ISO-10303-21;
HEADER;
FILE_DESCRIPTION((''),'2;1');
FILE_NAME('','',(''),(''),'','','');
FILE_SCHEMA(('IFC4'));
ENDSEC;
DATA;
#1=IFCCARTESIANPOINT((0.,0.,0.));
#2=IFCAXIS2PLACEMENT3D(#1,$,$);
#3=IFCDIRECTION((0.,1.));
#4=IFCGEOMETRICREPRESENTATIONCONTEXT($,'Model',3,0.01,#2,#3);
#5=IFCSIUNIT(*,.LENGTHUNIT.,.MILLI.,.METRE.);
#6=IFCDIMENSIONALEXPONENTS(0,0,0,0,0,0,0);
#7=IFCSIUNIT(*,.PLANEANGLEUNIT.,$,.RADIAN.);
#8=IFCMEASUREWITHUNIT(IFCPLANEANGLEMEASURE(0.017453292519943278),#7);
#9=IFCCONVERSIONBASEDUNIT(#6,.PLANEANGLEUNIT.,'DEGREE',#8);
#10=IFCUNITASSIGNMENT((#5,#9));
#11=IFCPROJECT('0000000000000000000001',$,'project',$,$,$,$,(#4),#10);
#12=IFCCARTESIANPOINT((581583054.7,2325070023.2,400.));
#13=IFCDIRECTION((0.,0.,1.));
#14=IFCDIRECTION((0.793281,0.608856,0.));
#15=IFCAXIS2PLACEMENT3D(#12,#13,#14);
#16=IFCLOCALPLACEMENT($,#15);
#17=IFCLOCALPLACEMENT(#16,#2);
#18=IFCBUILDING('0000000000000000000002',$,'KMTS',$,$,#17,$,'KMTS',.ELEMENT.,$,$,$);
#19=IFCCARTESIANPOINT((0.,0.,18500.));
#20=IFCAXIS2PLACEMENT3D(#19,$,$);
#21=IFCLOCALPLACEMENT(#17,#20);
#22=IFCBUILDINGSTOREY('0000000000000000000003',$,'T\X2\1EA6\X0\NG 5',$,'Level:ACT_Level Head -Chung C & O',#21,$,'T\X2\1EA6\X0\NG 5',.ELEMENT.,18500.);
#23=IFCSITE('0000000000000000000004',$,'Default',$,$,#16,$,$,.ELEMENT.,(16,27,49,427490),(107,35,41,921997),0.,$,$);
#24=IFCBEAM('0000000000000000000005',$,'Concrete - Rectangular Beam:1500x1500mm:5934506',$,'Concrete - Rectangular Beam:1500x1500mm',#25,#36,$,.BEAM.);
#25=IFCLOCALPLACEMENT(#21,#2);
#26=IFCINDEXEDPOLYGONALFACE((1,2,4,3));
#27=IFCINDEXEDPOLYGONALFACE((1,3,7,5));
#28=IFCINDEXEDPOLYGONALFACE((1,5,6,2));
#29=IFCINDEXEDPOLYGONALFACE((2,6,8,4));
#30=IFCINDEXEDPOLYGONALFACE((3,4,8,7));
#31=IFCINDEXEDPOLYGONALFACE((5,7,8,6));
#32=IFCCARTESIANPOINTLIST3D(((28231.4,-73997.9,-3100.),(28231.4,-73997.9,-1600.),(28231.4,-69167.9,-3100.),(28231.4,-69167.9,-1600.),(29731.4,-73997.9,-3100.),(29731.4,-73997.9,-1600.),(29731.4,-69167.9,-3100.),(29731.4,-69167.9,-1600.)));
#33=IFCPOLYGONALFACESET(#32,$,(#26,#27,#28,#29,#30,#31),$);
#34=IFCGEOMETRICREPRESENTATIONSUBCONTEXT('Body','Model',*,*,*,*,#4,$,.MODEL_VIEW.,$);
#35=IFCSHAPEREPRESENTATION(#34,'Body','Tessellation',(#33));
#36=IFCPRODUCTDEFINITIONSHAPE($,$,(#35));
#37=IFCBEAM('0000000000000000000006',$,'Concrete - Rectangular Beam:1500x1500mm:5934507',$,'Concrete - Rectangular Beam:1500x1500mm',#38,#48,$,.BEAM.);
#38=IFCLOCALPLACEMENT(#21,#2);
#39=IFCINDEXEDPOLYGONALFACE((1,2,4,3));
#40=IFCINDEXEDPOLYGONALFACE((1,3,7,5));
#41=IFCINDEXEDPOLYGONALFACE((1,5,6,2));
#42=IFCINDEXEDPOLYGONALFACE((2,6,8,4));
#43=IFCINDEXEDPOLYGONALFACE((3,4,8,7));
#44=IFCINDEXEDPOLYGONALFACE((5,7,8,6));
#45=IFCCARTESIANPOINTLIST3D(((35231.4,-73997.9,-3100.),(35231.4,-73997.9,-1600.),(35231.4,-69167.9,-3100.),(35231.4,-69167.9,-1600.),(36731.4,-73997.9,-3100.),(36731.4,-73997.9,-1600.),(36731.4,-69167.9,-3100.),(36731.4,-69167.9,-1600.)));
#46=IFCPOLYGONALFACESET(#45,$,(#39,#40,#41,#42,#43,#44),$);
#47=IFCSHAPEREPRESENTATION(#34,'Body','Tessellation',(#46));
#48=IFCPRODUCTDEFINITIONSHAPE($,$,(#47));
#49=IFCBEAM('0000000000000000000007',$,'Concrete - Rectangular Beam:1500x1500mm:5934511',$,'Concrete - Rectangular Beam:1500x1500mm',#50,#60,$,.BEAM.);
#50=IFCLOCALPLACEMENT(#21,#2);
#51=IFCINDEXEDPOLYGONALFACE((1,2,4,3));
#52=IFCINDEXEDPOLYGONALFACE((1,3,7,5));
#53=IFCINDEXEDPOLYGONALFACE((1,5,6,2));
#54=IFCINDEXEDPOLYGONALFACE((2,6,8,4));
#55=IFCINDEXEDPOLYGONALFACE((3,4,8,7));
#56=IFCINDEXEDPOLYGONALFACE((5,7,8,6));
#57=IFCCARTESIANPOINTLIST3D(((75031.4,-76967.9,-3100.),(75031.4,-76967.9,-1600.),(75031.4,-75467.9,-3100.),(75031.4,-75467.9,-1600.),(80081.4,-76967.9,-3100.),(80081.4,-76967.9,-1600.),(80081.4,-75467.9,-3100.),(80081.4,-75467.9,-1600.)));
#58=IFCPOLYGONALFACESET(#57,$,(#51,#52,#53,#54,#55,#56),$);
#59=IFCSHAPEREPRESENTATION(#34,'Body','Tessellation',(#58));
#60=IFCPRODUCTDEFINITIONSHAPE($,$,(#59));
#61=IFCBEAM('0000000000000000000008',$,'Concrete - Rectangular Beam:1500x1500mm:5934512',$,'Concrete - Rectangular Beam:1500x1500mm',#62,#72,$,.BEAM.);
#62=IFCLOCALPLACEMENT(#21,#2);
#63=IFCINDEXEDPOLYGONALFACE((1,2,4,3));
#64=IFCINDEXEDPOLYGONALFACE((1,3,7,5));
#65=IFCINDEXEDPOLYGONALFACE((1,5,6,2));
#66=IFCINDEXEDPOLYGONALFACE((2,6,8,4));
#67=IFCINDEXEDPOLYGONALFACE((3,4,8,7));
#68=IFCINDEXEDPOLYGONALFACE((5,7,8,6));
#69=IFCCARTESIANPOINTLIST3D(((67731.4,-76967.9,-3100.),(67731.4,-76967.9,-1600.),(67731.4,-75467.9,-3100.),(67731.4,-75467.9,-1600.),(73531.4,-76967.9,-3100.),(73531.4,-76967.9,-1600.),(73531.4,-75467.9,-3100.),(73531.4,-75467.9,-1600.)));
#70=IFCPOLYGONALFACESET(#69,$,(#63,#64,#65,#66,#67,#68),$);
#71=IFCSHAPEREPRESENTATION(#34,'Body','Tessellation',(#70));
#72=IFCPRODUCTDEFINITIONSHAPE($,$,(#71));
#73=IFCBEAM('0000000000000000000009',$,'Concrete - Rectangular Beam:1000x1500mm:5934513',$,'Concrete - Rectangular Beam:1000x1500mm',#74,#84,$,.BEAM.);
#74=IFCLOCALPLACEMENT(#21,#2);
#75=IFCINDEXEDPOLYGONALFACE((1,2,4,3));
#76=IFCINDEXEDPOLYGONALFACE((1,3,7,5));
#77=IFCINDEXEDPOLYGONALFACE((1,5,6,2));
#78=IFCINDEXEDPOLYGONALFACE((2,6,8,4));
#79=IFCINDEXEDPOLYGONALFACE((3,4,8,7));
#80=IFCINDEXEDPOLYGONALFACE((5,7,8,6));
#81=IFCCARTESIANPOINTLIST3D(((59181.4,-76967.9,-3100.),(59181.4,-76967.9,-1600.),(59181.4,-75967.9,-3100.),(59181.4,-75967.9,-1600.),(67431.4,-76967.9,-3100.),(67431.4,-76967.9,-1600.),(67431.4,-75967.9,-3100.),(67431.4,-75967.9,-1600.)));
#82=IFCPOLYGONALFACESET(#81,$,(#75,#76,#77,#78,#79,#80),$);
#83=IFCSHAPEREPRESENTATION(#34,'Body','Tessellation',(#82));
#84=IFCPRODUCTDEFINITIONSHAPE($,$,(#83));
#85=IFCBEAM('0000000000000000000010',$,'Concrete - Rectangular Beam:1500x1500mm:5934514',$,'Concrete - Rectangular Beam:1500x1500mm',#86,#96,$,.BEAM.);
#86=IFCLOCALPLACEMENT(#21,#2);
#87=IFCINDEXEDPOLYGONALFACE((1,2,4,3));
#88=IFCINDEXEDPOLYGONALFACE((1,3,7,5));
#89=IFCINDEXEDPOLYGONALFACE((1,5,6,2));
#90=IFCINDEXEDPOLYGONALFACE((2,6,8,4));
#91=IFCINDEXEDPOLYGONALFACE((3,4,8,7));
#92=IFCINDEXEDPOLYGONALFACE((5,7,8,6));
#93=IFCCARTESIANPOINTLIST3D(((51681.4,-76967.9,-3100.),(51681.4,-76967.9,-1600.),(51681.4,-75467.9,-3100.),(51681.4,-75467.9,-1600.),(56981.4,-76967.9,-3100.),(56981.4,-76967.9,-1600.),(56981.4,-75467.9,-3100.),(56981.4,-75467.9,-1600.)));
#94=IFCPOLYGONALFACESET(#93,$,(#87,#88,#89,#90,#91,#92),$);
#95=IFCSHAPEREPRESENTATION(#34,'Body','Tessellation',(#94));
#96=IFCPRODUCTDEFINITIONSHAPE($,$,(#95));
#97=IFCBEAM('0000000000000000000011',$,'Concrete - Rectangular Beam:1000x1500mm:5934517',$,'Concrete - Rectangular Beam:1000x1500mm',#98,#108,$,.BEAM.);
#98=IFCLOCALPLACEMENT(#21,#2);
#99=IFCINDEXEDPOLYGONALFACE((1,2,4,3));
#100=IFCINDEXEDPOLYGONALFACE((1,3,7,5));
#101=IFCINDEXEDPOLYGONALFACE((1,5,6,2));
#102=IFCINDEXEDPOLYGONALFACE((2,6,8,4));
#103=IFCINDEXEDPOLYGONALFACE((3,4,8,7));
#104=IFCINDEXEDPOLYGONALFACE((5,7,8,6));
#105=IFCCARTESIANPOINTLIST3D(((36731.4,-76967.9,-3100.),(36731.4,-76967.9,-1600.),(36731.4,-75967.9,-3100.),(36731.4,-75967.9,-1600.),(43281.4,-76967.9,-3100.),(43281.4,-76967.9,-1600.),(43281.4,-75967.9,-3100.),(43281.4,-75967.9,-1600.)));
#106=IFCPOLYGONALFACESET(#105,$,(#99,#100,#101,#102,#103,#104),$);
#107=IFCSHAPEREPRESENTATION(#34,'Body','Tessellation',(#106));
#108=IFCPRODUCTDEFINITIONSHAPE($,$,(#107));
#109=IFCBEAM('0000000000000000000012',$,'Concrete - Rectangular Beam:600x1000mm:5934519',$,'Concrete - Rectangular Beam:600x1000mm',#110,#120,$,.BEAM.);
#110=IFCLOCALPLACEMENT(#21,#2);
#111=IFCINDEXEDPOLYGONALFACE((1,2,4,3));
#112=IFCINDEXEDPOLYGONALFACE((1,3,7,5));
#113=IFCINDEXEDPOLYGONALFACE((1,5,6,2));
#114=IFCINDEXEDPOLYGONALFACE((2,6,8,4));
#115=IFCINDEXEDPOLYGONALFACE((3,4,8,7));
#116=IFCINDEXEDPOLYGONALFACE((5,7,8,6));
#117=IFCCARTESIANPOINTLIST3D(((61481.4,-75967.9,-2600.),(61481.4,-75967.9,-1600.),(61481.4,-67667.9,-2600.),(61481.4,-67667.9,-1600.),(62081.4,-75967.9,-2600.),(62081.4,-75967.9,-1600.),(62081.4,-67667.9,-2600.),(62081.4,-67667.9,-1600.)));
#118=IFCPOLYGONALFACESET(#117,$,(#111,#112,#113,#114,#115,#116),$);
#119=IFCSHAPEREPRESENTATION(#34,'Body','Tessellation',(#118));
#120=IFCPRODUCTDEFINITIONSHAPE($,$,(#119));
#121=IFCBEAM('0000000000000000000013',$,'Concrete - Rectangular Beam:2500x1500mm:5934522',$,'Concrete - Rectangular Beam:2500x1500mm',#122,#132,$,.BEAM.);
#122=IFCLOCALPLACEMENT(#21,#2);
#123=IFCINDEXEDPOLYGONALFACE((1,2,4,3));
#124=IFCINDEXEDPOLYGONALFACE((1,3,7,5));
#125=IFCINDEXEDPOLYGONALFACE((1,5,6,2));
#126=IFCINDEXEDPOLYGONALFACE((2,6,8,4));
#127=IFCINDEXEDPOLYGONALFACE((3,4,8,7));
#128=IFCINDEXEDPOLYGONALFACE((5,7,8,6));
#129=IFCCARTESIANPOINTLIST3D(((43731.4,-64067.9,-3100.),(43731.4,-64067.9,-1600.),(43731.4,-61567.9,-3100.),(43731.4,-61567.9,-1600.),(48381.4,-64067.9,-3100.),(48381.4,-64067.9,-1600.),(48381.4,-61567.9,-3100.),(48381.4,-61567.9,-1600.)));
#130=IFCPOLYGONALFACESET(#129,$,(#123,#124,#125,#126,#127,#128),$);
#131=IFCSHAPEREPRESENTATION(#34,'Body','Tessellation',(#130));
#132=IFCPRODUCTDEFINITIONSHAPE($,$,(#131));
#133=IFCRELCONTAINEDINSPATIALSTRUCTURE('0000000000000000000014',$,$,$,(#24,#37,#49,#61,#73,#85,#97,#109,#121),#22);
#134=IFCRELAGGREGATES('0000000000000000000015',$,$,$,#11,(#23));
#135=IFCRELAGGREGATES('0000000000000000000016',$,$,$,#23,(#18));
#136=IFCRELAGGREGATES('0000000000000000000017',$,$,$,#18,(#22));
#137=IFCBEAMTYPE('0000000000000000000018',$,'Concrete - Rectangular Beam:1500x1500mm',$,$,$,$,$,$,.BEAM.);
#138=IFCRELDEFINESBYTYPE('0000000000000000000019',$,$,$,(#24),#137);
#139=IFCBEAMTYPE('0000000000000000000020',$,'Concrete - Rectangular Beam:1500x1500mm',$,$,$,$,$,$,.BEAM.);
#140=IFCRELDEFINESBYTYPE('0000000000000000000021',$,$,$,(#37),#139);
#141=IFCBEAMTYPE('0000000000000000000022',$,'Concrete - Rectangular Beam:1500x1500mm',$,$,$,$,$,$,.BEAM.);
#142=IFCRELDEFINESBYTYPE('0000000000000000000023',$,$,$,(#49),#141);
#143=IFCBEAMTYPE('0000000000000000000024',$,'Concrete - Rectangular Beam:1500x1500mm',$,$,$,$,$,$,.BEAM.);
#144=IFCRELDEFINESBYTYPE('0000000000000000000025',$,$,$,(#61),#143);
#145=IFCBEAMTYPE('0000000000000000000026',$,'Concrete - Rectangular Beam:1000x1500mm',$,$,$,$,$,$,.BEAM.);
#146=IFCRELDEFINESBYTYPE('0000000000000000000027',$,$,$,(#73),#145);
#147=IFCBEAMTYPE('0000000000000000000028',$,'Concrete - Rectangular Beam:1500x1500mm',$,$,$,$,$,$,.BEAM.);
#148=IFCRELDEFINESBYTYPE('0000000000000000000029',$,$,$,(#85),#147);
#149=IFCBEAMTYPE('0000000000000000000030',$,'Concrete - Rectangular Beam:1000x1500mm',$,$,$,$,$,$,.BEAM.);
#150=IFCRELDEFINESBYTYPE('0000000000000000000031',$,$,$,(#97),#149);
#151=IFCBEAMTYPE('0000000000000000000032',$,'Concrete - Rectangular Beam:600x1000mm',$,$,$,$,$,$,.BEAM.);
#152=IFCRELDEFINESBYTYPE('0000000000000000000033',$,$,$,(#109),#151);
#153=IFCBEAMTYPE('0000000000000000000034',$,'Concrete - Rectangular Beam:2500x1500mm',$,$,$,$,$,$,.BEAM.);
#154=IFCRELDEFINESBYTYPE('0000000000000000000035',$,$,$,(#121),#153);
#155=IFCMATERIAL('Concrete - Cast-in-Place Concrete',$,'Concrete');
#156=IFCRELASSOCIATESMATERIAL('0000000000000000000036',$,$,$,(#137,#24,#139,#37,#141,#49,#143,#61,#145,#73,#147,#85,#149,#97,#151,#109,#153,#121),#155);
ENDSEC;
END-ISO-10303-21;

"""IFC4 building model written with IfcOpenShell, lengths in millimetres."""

from ifc_helpers import new_model, entity, si_unit, converted_unit, direction, frame, origin, place, context, subcontext, project, spatial, indexed_curve, outline, extrude, source, transform, mapped, material, type_object, type_shapes, element, save


model = new_model("IFC4")

# Units and contexts
model_context = context("Model", 3, precision=0.01, world=origin(), true_north=direction((0.0, 1.0)))
body_context = subcontext(model_context, "Body", "Model", "MODEL_VIEW")
ifc_project = project(units=[si_unit("LENGTHUNIT", "METRE", prefix="MILLI"), converted_unit("PLANEANGLEUNIT", "DEGREE", entity("IfcPlaneAngleMeasure", 0.017453292519943278), si_unit("PLANEANGLEUNIT", "RADIAN"), dimensions=[0, 0, 0, 0, 0, 0, 0])], contexts=[model_context])

# Site, building, storey
site_placement = place(None, frame((581583054.7, 2325070023.2, 400.0), z_axis=(0.0, 0.0, 1.0), x_axis=(0.793281, 0.608856, 0.0)))
site = spatial("IfcSite", under=ifc_project, at=site_placement, Name="Default", CompositionType="ELEMENT", RefLatitude=(16, 27, 49, 427490), RefLongitude=(107, 35, 41, 921997), RefElevation=0.0)
building_placement = place(site_placement, origin())
building = spatial("IfcBuilding", under=site, at=building_placement, Name="KMTS", LongName="KMTS", CompositionType="ELEMENT")
storey_placement = place(building_placement, frame((0.0, 0.0, 18500.0)))
storey = spatial("IfcBuildingStorey", under=building, at=storey_placement, Name="TẦNG 5", ObjectType="Level:ACT_Level Head -Chung C & O", LongName="TẦNG 5", CompositionType="ELEMENT", Elevation=18500.0)

# Beams
ifc_material_1 = material(Name="Concrete - Cast-in-Place Concrete", Category="Concrete")
beam_type_1 = type_object("IfcBeamType", Name="Concrete - Rectangular Beam:1500x1500mm", PredefinedType="BEAM", material=ifc_material_1)
shared_shape_1 = source(origin(), body_context, "Body", "SweptSolid", [
    extrude(outline(indexed_curve([(-750.0, -750.0), (750.0, -750.0), (750.0, 750.0), (-750.0, 750.0), (-750.0, -750.0)], self_intersect=False)), frame((28981.4, -69167.9, 16150.0), z_axis=(0.0, -1.0, 0.0), x_axis=(-1.0, 0.0, 0.0)), (0.0, 0.0, 1.0), 4830.0),
])
type_shapes(beam_type_1, [shared_shape_1])
beam_1_placement = place(storey_placement, frame((0.0, 0.0, -18500.0)))
element("IfcBeam", 1, at=beam_1_placement, inside=storey, type_object=beam_type_1, material=ifc_material_1, Name="Concrete - Rectangular Beam:1500x1500mm:5934506", ObjectType="Concrete - Rectangular Beam:1500x1500mm", PredefinedType="BEAM", context=body_context, shape_type="MappedRepresentation", body=[
    mapped(shared_shape_1, transform((0.0, 0.0, 0.0), scale=1.0)),
])
beam_type_2 = type_object("IfcBeamType", Name="Concrete - Rectangular Beam:1500x1500mm", PredefinedType="BEAM", material=ifc_material_1)
shared_shape_2 = source(origin(), body_context, "Body", "SweptSolid", [
    extrude(outline(indexed_curve([(-750.0, -750.0), (750.0, -750.0), (750.0, 750.0), (-750.0, 750.0), (-750.0, -750.0)], self_intersect=False)), frame((35981.4, -73997.9, 16150.0), z_axis=(0.0, 1.0, 0.0), x_axis=(-1.0, 0.0, 0.0)), (0.0, 0.0, 1.0), 4830.0),
])
type_shapes(beam_type_2, [shared_shape_2])
beam_2_placement = place(storey_placement, frame((0.0, 0.0, -18500.0)))
element("IfcBeam", 2, at=beam_2_placement, inside=storey, type_object=beam_type_2, material=ifc_material_1, Name="Concrete - Rectangular Beam:1500x1500mm:5934507", ObjectType="Concrete - Rectangular Beam:1500x1500mm", PredefinedType="BEAM", context=body_context, shape_type="MappedRepresentation", body=[
    mapped(shared_shape_2, transform((0.0, 0.0, 0.0), scale=1.0)),
])
beam_type_3 = type_object("IfcBeamType", Name="Concrete - Rectangular Beam:1500x1500mm", PredefinedType="BEAM", material=ifc_material_1)
shared_shape_3 = source(origin(), body_context, "Body", "SweptSolid", [
    extrude(outline(indexed_curve([(-750.0, -750.0), (750.0, -750.0), (750.0, 750.0), (-750.0, 750.0), (-750.0, -750.0)], self_intersect=False)), frame((80081.4, -76217.9, 16150.0), z_axis=(-1.0, 0.0, 0.0), x_axis=(0.0, 0.0, -1.0)), (0.0, 0.0, 1.0), 5050.0),
])
type_shapes(beam_type_3, [shared_shape_3])
beam_3_placement = place(storey_placement, frame((0.0, 0.0, -18500.0)))
element("IfcBeam", 3, at=beam_3_placement, inside=storey, type_object=beam_type_3, material=ifc_material_1, Name="Concrete - Rectangular Beam:1500x1500mm:5934511", ObjectType="Concrete - Rectangular Beam:1500x1500mm", PredefinedType="BEAM", context=body_context, shape_type="MappedRepresentation", body=[
    mapped(shared_shape_3, transform((0.0, 0.0, 0.0), scale=1.0)),
])
beam_type_4 = type_object("IfcBeamType", Name="Concrete - Rectangular Beam:1500x1500mm", PredefinedType="BEAM", material=ifc_material_1)
shared_shape_4 = source(origin(), body_context, "Body", "SweptSolid", [
    extrude(outline(indexed_curve([(-750.0, -750.0), (750.0, -750.0), (750.0, 750.0), (-750.0, 750.0), (-750.0, -750.0)], self_intersect=False)), frame((73531.4, -76217.9, 16150.0), z_axis=(-1.0, 0.0, 0.0), x_axis=(0.0, 0.0, -1.0)), (0.0, 0.0, 1.0), 5800.0),
])
type_shapes(beam_type_4, [shared_shape_4])
beam_4_placement = place(storey_placement, frame((0.0, 0.0, -18500.0)))
element("IfcBeam", 4, at=beam_4_placement, inside=storey, type_object=beam_type_4, material=ifc_material_1, Name="Concrete - Rectangular Beam:1500x1500mm:5934512", ObjectType="Concrete - Rectangular Beam:1500x1500mm", PredefinedType="BEAM", context=body_context, shape_type="MappedRepresentation", body=[
    mapped(shared_shape_4, transform((0.0, 0.0, 0.0), scale=1.0)),
])
beam_type_5 = type_object("IfcBeamType", Name="Concrete - Rectangular Beam:1000x1500mm", PredefinedType="BEAM", material=ifc_material_1)
shared_shape_5 = source(origin(), body_context, "Body", "SweptSolid", [
    extrude(outline(indexed_curve([(-750.0, -500.0), (750.0, -500.0), (750.0, 500.0), (-750.0, 500.0), (-750.0, -500.0)], self_intersect=False)), frame((67431.4, -76467.9, 16150.0), z_axis=(-1.0, 0.0, 0.0), x_axis=(0.0, 0.0, -1.0)), (0.0, 0.0, 1.0), 8250.0),
])
type_shapes(beam_type_5, [shared_shape_5])
beam_5_placement = place(storey_placement, frame((0.0, 0.0, -18500.0)))
element("IfcBeam", 5, at=beam_5_placement, inside=storey, type_object=beam_type_5, material=ifc_material_1, Name="Concrete - Rectangular Beam:1000x1500mm:5934513", ObjectType="Concrete - Rectangular Beam:1000x1500mm", PredefinedType="BEAM", context=body_context, shape_type="MappedRepresentation", body=[
    mapped(shared_shape_5, transform((0.0, 0.0, 0.0), scale=1.0)),
])
beam_type_6 = type_object("IfcBeamType", Name="Concrete - Rectangular Beam:1500x1500mm", PredefinedType="BEAM", material=ifc_material_1)
shared_shape_6 = source(origin(), body_context, "Body", "SweptSolid", [
    extrude(outline(indexed_curve([(-750.0, -750.0), (750.0, -750.0), (750.0, 750.0), (-750.0, 750.0), (-750.0, -750.0)], self_intersect=False)), frame((56981.4, -76217.9, 16150.0), z_axis=(-1.0, 0.0, 0.0), x_axis=(0.0, 0.0, -1.0)), (0.0, 0.0, 1.0), 5300.0),
])
type_shapes(beam_type_6, [shared_shape_6])
beam_6_placement = place(storey_placement, frame((0.0, 0.0, -18500.0)))
element("IfcBeam", 6, at=beam_6_placement, inside=storey, type_object=beam_type_6, material=ifc_material_1, Name="Concrete - Rectangular Beam:1500x1500mm:5934514", ObjectType="Concrete - Rectangular Beam:1500x1500mm", PredefinedType="BEAM", context=body_context, shape_type="MappedRepresentation", body=[
    mapped(shared_shape_6, transform((0.0, 0.0, 0.0), scale=1.0)),
])
beam_type_7 = type_object("IfcBeamType", Name="Concrete - Rectangular Beam:1000x1500mm", PredefinedType="BEAM", material=ifc_material_1)
shared_shape_7 = source(origin(), body_context, "Body", "SweptSolid", [
    extrude(outline(indexed_curve([(-750.0, -500.0), (750.0, -500.0), (750.0, 500.0), (-750.0, 500.0), (-750.0, -500.0)], self_intersect=False)), frame((43281.4, -76467.9, 16150.0), z_axis=(-1.0, 0.0, 0.0), x_axis=(0.0, 0.0, -1.0)), (0.0, 0.0, 1.0), 6550.0),
])
type_shapes(beam_type_7, [shared_shape_7])
beam_7_placement = place(storey_placement, frame((0.0, 0.0, -18500.0)))
element("IfcBeam", 7, at=beam_7_placement, inside=storey, type_object=beam_type_7, material=ifc_material_1, Name="Concrete - Rectangular Beam:1000x1500mm:5934517", ObjectType="Concrete - Rectangular Beam:1000x1500mm", PredefinedType="BEAM", context=body_context, shape_type="MappedRepresentation", body=[
    mapped(shared_shape_7, transform((0.0, 0.0, 0.0), scale=1.0)),
])
beam_type_8 = type_object("IfcBeamType", Name="Concrete - Rectangular Beam:600x1000mm", PredefinedType="BEAM", material=ifc_material_1)
shared_shape_8 = source(origin(), body_context, "Body", "SweptSolid", [
    extrude(outline(indexed_curve([(-300.0, -500.0), (300.0, -500.0), (300.0, 500.0), (-300.0, 500.0), (-300.0, -500.0)], self_intersect=False)), frame((61781.4, -67667.9, 16400.0), z_axis=(0.0, -1.0, 0.0), x_axis=(-1.0, 0.0, 0.0)), (0.0, 0.0, 1.0), 8300.0),
])
type_shapes(beam_type_8, [shared_shape_8])
beam_8_placement = place(storey_placement, frame((0.0, 0.0, -18500.0)))
element("IfcBeam", 8, at=beam_8_placement, inside=storey, type_object=beam_type_8, material=ifc_material_1, Name="Concrete - Rectangular Beam:600x1000mm:5934519", ObjectType="Concrete - Rectangular Beam:600x1000mm", PredefinedType="BEAM", context=body_context, shape_type="MappedRepresentation", body=[
    mapped(shared_shape_8, transform((0.0, 0.0, 0.0), scale=1.0)),
])
beam_type_9 = type_object("IfcBeamType", Name="Concrete - Rectangular Beam:2500x1500mm", PredefinedType="BEAM", material=ifc_material_1)
shared_shape_9 = source(origin(), body_context, "Body", "SweptSolid", [
    extrude(outline(indexed_curve([(-750.0, -1250.0), (750.0, -1250.0), (750.0, 1250.0), (-750.0, 1250.0), (-750.0, -1250.0)], self_intersect=False)), frame((48381.4, -62817.9, 16150.0), z_axis=(-1.0, 0.0, 0.0), x_axis=(0.0, 0.0, -1.0)), (0.0, 0.0, 1.0), 4650.0),
])
type_shapes(beam_type_9, [shared_shape_9])
beam_9_placement = place(storey_placement, frame((0.0, 0.0, -18500.0)))
element("IfcBeam", 9, at=beam_9_placement, inside=storey, type_object=beam_type_9, material=ifc_material_1, Name="Concrete - Rectangular Beam:2500x1500mm:5934522", ObjectType="Concrete - Rectangular Beam:2500x1500mm", PredefinedType="BEAM", context=body_context, shape_type="MappedRepresentation", body=[
    mapped(shared_shape_9, transform((0.0, 0.0, 0.0), scale=1.0)),
])

save(model, "model.ifc")
